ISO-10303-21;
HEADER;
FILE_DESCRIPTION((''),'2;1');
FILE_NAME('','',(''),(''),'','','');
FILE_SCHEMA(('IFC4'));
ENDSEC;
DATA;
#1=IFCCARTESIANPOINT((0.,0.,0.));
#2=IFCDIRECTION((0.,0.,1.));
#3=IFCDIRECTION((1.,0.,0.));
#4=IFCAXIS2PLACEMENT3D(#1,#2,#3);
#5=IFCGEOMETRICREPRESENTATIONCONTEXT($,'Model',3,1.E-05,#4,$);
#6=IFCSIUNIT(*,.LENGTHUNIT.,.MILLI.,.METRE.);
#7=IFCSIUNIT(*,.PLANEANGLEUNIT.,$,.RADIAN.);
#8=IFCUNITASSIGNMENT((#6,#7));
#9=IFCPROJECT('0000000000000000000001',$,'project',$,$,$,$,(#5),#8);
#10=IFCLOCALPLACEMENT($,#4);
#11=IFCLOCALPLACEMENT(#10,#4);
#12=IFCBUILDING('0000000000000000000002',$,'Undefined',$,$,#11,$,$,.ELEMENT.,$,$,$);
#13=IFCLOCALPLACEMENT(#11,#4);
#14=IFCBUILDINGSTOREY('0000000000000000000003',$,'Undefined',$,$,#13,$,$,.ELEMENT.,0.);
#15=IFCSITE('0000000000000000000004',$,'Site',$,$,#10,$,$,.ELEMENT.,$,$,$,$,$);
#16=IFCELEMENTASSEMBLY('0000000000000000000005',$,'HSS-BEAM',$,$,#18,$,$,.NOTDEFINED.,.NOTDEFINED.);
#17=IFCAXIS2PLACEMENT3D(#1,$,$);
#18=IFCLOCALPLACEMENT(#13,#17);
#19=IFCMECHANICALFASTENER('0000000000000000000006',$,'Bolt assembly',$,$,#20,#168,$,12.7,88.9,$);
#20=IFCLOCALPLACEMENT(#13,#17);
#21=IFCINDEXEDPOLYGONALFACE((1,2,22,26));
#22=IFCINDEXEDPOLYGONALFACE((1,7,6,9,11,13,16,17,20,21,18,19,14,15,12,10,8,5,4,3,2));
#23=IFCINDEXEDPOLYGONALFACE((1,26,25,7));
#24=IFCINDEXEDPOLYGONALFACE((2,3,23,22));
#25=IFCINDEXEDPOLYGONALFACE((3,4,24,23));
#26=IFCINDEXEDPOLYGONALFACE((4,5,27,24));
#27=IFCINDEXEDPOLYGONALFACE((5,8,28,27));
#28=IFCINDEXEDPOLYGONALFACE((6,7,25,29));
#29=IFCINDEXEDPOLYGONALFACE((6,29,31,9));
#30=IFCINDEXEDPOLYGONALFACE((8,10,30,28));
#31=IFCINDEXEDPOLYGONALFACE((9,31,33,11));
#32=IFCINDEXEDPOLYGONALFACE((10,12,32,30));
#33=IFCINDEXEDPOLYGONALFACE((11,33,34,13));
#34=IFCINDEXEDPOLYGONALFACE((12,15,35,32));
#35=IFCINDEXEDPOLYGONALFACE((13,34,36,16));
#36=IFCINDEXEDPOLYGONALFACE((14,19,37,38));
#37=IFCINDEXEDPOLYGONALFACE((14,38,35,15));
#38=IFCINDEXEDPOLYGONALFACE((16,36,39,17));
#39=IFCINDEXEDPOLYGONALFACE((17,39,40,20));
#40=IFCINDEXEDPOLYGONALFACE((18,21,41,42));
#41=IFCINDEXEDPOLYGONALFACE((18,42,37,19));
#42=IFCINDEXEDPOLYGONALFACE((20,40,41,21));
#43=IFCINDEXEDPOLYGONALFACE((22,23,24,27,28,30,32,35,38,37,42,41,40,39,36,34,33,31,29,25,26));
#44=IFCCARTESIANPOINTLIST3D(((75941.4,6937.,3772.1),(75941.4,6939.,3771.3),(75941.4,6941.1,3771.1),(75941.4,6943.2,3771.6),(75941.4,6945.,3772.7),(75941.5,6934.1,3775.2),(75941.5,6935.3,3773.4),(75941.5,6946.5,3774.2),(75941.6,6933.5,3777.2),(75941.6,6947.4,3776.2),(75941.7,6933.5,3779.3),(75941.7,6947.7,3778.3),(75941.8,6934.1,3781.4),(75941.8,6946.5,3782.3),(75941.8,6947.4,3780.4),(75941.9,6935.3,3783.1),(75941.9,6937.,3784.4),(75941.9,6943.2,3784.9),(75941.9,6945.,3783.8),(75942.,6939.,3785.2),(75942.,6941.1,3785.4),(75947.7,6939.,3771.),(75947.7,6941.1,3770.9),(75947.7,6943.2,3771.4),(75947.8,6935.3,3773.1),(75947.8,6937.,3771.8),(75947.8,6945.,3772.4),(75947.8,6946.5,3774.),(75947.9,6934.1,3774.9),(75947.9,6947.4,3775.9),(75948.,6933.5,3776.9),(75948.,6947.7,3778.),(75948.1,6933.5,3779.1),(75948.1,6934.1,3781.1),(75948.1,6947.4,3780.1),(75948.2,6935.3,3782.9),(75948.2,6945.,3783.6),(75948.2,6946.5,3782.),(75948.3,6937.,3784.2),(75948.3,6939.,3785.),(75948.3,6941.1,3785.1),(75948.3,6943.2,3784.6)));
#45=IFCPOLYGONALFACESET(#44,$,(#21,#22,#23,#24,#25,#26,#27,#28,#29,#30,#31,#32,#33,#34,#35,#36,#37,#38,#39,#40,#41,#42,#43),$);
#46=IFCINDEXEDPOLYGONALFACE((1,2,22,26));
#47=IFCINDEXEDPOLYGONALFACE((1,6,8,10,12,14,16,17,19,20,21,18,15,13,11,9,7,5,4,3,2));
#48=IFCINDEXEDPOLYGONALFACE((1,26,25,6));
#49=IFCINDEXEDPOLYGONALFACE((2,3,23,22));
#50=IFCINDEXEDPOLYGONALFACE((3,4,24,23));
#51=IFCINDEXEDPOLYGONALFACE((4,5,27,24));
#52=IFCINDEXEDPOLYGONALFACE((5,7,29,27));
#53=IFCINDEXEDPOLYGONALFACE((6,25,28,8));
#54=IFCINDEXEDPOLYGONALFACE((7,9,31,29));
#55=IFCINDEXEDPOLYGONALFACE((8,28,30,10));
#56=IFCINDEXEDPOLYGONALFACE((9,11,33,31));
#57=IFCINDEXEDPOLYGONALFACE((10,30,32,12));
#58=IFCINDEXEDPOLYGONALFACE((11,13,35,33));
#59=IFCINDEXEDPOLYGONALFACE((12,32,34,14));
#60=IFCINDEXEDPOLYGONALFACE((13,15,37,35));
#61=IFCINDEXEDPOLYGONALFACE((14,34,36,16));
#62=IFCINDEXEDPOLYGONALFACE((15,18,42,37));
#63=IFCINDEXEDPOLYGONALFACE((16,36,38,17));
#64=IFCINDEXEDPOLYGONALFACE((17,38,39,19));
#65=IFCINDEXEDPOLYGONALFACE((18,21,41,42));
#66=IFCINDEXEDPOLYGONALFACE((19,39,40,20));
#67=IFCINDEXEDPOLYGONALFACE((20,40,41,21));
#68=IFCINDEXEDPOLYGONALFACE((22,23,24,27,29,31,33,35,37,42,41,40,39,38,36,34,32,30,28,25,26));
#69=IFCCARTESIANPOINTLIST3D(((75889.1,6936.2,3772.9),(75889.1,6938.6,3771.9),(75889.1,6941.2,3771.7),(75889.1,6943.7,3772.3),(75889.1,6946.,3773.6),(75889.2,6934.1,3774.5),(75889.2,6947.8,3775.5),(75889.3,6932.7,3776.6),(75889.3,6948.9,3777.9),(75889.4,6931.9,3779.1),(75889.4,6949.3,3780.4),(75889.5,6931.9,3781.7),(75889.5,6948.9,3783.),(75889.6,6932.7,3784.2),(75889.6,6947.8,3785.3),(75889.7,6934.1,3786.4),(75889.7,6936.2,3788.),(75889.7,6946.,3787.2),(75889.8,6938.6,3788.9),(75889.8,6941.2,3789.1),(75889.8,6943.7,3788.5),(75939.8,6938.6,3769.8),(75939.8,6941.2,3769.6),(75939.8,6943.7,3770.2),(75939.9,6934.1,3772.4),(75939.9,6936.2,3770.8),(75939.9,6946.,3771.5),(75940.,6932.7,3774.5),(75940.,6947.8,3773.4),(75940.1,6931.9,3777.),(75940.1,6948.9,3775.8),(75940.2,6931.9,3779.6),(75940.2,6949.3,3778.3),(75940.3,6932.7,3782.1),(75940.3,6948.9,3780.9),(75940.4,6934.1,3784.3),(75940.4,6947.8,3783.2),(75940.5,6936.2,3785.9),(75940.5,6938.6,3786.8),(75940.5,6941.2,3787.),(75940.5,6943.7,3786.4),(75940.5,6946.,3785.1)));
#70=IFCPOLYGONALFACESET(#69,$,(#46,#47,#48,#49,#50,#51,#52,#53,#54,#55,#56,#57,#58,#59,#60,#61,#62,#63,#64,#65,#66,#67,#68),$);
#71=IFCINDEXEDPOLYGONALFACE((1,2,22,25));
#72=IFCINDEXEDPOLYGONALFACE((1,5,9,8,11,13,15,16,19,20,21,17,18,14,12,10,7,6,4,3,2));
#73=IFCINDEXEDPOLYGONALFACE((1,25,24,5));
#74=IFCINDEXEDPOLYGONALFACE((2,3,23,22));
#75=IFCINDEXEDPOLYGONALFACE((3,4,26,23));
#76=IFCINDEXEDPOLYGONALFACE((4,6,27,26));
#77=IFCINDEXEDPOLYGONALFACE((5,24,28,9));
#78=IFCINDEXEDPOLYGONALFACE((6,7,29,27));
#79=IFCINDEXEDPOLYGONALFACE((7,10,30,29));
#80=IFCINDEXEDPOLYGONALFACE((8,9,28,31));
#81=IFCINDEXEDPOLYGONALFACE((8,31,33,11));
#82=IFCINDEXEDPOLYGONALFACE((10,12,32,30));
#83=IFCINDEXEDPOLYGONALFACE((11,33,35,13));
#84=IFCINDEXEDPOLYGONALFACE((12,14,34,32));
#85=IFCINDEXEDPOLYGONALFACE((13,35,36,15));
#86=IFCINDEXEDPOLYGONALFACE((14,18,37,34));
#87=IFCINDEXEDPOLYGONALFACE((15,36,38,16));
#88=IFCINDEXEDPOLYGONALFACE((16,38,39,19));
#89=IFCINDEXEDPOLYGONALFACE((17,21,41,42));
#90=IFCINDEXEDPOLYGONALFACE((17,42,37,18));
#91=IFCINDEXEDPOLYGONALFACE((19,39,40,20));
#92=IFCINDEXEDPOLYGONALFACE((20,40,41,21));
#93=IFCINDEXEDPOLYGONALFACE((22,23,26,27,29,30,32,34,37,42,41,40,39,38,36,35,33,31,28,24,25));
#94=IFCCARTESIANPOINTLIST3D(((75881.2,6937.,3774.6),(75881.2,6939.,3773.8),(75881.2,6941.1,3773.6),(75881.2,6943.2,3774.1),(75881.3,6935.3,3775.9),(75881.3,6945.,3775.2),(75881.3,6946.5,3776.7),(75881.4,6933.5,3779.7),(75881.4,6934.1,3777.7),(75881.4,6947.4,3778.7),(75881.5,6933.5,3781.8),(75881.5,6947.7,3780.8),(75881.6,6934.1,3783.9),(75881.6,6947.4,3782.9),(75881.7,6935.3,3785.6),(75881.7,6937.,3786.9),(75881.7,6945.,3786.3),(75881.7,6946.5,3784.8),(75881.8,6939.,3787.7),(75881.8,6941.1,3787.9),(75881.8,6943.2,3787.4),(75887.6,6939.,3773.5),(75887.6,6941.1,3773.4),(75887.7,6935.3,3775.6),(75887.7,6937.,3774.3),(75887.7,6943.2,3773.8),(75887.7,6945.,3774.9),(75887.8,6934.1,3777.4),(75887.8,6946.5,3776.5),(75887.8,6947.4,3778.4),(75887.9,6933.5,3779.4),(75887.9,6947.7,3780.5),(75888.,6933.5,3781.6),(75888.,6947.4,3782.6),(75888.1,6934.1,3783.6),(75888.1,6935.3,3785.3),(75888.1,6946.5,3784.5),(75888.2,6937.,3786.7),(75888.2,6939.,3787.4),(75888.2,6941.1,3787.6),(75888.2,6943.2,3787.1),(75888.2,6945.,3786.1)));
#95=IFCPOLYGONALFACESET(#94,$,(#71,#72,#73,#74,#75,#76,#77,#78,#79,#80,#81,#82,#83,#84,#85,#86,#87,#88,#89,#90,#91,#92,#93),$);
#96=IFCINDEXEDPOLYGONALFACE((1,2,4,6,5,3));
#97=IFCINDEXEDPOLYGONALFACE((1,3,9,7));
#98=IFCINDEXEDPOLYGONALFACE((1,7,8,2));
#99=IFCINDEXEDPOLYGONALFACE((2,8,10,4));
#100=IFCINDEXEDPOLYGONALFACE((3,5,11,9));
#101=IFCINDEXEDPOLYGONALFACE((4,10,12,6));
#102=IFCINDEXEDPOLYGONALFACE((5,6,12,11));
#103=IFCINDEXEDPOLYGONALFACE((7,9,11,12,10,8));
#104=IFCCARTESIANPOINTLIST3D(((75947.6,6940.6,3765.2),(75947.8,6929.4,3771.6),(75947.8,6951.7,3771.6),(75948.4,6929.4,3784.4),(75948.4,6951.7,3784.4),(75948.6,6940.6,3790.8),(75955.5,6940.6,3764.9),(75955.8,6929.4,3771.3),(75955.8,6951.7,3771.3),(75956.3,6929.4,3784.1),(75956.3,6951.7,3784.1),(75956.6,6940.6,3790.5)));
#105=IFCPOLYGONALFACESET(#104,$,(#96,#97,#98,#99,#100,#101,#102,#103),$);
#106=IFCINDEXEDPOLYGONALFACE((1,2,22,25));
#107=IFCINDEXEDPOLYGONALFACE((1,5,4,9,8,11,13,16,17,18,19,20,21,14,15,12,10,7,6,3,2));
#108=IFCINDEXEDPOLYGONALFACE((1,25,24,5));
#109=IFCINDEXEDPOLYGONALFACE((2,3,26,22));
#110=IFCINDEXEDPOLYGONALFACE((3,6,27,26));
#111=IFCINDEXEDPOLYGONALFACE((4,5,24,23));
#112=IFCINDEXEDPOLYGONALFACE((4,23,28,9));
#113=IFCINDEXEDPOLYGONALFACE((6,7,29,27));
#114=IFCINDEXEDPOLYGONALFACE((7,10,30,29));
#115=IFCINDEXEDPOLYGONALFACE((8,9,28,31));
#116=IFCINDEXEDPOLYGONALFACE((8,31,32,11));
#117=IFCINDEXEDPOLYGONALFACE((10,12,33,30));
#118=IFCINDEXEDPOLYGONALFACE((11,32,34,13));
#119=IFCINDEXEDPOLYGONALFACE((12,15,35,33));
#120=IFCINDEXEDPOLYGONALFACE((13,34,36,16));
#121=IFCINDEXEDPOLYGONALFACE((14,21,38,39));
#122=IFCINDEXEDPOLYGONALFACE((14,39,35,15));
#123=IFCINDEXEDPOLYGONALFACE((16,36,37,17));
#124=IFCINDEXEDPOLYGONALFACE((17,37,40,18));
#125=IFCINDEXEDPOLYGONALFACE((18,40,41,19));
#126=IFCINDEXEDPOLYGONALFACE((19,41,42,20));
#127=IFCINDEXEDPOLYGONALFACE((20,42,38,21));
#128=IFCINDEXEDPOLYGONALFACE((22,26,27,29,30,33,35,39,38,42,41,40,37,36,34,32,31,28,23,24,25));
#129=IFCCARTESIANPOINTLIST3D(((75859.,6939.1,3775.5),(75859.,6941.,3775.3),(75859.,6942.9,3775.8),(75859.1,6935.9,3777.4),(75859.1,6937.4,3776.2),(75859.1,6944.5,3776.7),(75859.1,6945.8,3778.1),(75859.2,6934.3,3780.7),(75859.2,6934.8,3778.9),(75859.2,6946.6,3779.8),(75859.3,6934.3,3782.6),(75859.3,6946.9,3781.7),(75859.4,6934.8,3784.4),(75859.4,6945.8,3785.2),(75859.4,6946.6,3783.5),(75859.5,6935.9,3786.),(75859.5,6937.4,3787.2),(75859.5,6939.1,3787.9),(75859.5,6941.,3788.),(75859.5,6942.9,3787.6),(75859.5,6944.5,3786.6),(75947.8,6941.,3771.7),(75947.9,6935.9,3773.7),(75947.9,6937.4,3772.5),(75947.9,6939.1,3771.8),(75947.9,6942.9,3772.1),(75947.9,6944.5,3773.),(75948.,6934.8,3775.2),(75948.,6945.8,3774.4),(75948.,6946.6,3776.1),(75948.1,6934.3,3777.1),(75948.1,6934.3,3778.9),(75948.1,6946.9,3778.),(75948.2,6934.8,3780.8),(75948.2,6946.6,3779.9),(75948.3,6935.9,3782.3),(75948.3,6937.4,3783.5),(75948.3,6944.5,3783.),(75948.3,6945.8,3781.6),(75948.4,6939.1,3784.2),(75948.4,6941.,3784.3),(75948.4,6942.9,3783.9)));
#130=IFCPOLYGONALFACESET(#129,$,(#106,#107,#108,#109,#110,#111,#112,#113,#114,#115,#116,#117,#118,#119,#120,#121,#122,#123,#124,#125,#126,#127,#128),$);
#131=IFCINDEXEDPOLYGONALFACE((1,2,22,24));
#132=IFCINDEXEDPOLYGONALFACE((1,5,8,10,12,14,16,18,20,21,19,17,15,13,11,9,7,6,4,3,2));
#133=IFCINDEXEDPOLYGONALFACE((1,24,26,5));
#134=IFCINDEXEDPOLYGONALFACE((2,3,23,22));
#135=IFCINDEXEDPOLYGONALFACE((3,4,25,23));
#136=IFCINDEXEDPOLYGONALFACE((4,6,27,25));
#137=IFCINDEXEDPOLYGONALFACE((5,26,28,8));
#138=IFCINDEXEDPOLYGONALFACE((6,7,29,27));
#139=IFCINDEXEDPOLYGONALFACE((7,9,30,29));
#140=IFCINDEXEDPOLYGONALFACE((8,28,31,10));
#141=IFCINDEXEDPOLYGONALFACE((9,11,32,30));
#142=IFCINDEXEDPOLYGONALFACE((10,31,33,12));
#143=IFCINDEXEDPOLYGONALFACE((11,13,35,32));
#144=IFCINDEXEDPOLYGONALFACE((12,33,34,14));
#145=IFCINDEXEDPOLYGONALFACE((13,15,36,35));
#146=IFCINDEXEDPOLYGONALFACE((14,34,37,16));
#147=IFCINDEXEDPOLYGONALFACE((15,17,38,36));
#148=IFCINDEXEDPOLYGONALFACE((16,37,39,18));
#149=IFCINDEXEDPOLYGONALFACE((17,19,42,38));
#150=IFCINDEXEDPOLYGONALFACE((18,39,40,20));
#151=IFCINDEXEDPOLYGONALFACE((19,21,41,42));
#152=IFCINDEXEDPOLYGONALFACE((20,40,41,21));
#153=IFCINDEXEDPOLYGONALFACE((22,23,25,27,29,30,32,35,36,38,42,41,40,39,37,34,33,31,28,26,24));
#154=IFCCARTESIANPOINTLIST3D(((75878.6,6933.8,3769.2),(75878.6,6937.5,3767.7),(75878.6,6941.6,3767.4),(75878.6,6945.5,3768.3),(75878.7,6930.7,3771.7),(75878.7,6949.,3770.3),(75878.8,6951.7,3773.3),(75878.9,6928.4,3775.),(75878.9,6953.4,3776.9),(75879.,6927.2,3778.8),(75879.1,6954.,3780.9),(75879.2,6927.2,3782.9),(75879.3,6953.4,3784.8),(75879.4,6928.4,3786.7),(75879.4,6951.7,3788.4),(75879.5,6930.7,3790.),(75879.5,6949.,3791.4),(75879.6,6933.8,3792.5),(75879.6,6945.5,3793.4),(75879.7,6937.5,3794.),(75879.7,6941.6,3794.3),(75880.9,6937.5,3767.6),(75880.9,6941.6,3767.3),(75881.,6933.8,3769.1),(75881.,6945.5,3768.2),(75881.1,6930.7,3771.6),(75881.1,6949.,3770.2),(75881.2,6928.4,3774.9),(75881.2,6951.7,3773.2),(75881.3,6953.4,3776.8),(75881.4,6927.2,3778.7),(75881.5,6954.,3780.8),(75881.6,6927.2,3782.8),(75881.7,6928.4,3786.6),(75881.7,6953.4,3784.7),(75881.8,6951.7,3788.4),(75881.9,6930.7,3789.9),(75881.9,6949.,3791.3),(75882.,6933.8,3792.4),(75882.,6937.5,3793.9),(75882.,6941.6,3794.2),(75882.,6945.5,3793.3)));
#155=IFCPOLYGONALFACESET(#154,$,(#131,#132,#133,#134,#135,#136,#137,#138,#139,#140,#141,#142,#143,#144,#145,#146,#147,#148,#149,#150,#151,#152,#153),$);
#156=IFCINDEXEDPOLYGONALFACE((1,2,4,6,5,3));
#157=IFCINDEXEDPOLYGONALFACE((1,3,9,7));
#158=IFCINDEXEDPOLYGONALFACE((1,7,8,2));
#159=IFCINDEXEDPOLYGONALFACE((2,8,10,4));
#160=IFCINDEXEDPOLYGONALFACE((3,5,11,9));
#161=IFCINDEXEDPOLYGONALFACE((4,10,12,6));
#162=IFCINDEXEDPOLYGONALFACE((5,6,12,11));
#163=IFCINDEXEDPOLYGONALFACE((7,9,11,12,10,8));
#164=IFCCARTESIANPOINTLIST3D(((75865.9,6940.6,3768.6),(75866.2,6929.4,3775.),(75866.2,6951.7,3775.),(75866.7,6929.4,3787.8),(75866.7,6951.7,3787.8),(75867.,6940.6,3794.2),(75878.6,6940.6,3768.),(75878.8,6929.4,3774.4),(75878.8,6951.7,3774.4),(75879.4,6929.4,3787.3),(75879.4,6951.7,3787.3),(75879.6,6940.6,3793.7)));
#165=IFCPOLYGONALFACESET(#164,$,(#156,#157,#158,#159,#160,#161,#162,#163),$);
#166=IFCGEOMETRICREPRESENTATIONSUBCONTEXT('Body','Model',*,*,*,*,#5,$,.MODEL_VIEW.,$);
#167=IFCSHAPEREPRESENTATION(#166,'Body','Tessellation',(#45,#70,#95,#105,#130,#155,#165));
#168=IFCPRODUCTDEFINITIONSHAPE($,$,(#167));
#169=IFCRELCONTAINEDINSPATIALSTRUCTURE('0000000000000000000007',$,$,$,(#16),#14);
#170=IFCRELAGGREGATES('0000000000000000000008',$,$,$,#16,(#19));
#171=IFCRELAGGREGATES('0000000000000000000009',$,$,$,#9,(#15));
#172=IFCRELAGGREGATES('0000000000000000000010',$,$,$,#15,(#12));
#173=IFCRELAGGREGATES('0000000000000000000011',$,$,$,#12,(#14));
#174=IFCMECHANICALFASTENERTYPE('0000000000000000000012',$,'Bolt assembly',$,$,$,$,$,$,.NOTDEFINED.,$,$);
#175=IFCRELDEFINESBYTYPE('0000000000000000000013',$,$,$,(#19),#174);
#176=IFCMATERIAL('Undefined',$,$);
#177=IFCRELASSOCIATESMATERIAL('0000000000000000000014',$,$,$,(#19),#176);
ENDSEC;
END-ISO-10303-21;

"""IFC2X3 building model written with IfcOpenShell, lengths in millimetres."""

from ifc_helpers import new_model, si_unit, frame, origin_with_axes, origin_2d_with_axis, place, context, subcontext, project, spatial, polyline, circle, outline, extrude, source, transform, mapped, material, type_object, element, aggregate, save


model = new_model("IFC2X3")

# Units and contexts
model_context = context("Model", 3, precision=1e-05, world=origin_with_axes())
body_context = subcontext(model_context, "Body", "Model", "MODEL_VIEW")
ifc_project = project(units=[si_unit("LENGTHUNIT", "METRE", prefix="MILLI"), si_unit("PLANEANGLEUNIT", "RADIAN")], contexts=[model_context])

# Site, building, storey
site_placement = place(None, origin_with_axes())
site = spatial("IfcSite", under=ifc_project, at=site_placement, Name="Site", CompositionType="ELEMENT")
building_placement = place(site_placement, origin_with_axes())
building = spatial("IfcBuilding", under=site, at=building_placement, Name="Undefined", CompositionType="ELEMENT")
storey_placement = place(building_placement, origin_with_axes())
storey = spatial("IfcBuildingStorey", under=building, at=storey_placement, Name="Undefined", CompositionType="ELEMENT", Elevation=0.0)

# Element assembly
assembly_1_placement = place(storey_placement, origin_with_axes())
assembly_1 = element("IfcElementAssembly", 1, at=assembly_1_placement, inside=storey, Name="HSS-BEAM", AssemblyPlace="NOTDEFINED", PredefinedType="NOTDEFINED")

# Shared definitions
ifc_material_1 = material(Name="Undefined")
mechanical_fastener_type = type_object("IfcMechanicalFastenerType", Name="Bolt assembly")

# Shared definitions
shared_shape_1 = source(origin_with_axes(), body_context, "Body", "SweptSolid", [
    extrude(circle(Radius=7.1, at=origin_2d_with_axis()), frame((0.0, -33.2, 0.0), z_axis=(0.0, 1.0, 0.0), x_axis=(1.0, 0.0, 0.0)), (0.0, 0.0, 1.0), 6.3),
    extrude(circle(Radius=8.7, at=origin_2d_with_axis()), frame((0.0, -25.4, 0.0), z_axis=(0.0, 1.0, 0.0), x_axis=(1.0, 0.0, 0.0)), (0.0, 0.0, 1.0), 50.8),
    extrude(circle(Radius=7.1, at=origin_2d_with_axis()), frame((0.0, 26.9, 0.0), z_axis=(0.0, 1.0, 0.0), x_axis=(1.0, 0.0, 0.0)), (0.0, 0.0, 1.0), 6.5),
    extrude(outline(polyline([(11.1, -6.4), (11.1, 6.4), (0.0, 12.8), (-11.1, 6.4), (-11.1, -6.4), (0.0, -12.8), (11.1, -6.4)])), frame((0.0, -41.3, 0.0), z_axis=(0.0, 1.0, 0.0), x_axis=(1.0, 0.0, 0.0)), (0.0, 0.0, 1.0), 7.9),
    extrude(circle(Radius=6.3, at=origin_2d_with_axis()), frame((0.0, -33.3, 0.0), z_axis=(0.0, 1.0, 0.0), x_axis=(1.0, 0.0, 0.0)), (0.0, 0.0, 1.0), 88.9),
    extrude(circle(Radius=13.5, at=origin_2d_with_axis()), frame((0.0, 33.3, 0.0), z_axis=(0.0, 1.0, 0.0), x_axis=(1.0, 0.0, 0.0)), (0.0, 0.0, 1.0), 2.4),
    extrude(outline(polyline([(11.1, -6.4), (11.1, 6.4), (0.0, 12.8), (-11.1, 6.4), (-11.1, -6.4), (0.0, -12.8), (11.1, -6.4)])), frame((0.0, 35.7, 0.0), z_axis=(0.0, 1.0, 0.0), x_axis=(1.0, 0.0, 0.0)), (0.0, 0.0, 1.0), 12.7),
])

# Mechanical fastener
mechanical_fastener_1_placement = place(assembly_1_placement, frame((75914.8, 6940.6, 3779.4), z_axis=(0.041337, 0.0, 0.999145), x_axis=(0.0, 1.0, 0.0)))
mechanical_fastener_1 = element("IfcMechanicalFastener", 2, at=mechanical_fastener_1_placement, type_object=mechanical_fastener_type, material=ifc_material_1, Name="Bolt assembly", NominalDiameter=12.7, NominalLength=88.9, context=body_context, shape_type="MappedRepresentation", body=[
    mapped(shared_shape_1, transform((0.0, 0.0, 0.0))),
])
aggregate(assembly_1, [mechanical_fastener_1])

save(model, "model.ifc")
